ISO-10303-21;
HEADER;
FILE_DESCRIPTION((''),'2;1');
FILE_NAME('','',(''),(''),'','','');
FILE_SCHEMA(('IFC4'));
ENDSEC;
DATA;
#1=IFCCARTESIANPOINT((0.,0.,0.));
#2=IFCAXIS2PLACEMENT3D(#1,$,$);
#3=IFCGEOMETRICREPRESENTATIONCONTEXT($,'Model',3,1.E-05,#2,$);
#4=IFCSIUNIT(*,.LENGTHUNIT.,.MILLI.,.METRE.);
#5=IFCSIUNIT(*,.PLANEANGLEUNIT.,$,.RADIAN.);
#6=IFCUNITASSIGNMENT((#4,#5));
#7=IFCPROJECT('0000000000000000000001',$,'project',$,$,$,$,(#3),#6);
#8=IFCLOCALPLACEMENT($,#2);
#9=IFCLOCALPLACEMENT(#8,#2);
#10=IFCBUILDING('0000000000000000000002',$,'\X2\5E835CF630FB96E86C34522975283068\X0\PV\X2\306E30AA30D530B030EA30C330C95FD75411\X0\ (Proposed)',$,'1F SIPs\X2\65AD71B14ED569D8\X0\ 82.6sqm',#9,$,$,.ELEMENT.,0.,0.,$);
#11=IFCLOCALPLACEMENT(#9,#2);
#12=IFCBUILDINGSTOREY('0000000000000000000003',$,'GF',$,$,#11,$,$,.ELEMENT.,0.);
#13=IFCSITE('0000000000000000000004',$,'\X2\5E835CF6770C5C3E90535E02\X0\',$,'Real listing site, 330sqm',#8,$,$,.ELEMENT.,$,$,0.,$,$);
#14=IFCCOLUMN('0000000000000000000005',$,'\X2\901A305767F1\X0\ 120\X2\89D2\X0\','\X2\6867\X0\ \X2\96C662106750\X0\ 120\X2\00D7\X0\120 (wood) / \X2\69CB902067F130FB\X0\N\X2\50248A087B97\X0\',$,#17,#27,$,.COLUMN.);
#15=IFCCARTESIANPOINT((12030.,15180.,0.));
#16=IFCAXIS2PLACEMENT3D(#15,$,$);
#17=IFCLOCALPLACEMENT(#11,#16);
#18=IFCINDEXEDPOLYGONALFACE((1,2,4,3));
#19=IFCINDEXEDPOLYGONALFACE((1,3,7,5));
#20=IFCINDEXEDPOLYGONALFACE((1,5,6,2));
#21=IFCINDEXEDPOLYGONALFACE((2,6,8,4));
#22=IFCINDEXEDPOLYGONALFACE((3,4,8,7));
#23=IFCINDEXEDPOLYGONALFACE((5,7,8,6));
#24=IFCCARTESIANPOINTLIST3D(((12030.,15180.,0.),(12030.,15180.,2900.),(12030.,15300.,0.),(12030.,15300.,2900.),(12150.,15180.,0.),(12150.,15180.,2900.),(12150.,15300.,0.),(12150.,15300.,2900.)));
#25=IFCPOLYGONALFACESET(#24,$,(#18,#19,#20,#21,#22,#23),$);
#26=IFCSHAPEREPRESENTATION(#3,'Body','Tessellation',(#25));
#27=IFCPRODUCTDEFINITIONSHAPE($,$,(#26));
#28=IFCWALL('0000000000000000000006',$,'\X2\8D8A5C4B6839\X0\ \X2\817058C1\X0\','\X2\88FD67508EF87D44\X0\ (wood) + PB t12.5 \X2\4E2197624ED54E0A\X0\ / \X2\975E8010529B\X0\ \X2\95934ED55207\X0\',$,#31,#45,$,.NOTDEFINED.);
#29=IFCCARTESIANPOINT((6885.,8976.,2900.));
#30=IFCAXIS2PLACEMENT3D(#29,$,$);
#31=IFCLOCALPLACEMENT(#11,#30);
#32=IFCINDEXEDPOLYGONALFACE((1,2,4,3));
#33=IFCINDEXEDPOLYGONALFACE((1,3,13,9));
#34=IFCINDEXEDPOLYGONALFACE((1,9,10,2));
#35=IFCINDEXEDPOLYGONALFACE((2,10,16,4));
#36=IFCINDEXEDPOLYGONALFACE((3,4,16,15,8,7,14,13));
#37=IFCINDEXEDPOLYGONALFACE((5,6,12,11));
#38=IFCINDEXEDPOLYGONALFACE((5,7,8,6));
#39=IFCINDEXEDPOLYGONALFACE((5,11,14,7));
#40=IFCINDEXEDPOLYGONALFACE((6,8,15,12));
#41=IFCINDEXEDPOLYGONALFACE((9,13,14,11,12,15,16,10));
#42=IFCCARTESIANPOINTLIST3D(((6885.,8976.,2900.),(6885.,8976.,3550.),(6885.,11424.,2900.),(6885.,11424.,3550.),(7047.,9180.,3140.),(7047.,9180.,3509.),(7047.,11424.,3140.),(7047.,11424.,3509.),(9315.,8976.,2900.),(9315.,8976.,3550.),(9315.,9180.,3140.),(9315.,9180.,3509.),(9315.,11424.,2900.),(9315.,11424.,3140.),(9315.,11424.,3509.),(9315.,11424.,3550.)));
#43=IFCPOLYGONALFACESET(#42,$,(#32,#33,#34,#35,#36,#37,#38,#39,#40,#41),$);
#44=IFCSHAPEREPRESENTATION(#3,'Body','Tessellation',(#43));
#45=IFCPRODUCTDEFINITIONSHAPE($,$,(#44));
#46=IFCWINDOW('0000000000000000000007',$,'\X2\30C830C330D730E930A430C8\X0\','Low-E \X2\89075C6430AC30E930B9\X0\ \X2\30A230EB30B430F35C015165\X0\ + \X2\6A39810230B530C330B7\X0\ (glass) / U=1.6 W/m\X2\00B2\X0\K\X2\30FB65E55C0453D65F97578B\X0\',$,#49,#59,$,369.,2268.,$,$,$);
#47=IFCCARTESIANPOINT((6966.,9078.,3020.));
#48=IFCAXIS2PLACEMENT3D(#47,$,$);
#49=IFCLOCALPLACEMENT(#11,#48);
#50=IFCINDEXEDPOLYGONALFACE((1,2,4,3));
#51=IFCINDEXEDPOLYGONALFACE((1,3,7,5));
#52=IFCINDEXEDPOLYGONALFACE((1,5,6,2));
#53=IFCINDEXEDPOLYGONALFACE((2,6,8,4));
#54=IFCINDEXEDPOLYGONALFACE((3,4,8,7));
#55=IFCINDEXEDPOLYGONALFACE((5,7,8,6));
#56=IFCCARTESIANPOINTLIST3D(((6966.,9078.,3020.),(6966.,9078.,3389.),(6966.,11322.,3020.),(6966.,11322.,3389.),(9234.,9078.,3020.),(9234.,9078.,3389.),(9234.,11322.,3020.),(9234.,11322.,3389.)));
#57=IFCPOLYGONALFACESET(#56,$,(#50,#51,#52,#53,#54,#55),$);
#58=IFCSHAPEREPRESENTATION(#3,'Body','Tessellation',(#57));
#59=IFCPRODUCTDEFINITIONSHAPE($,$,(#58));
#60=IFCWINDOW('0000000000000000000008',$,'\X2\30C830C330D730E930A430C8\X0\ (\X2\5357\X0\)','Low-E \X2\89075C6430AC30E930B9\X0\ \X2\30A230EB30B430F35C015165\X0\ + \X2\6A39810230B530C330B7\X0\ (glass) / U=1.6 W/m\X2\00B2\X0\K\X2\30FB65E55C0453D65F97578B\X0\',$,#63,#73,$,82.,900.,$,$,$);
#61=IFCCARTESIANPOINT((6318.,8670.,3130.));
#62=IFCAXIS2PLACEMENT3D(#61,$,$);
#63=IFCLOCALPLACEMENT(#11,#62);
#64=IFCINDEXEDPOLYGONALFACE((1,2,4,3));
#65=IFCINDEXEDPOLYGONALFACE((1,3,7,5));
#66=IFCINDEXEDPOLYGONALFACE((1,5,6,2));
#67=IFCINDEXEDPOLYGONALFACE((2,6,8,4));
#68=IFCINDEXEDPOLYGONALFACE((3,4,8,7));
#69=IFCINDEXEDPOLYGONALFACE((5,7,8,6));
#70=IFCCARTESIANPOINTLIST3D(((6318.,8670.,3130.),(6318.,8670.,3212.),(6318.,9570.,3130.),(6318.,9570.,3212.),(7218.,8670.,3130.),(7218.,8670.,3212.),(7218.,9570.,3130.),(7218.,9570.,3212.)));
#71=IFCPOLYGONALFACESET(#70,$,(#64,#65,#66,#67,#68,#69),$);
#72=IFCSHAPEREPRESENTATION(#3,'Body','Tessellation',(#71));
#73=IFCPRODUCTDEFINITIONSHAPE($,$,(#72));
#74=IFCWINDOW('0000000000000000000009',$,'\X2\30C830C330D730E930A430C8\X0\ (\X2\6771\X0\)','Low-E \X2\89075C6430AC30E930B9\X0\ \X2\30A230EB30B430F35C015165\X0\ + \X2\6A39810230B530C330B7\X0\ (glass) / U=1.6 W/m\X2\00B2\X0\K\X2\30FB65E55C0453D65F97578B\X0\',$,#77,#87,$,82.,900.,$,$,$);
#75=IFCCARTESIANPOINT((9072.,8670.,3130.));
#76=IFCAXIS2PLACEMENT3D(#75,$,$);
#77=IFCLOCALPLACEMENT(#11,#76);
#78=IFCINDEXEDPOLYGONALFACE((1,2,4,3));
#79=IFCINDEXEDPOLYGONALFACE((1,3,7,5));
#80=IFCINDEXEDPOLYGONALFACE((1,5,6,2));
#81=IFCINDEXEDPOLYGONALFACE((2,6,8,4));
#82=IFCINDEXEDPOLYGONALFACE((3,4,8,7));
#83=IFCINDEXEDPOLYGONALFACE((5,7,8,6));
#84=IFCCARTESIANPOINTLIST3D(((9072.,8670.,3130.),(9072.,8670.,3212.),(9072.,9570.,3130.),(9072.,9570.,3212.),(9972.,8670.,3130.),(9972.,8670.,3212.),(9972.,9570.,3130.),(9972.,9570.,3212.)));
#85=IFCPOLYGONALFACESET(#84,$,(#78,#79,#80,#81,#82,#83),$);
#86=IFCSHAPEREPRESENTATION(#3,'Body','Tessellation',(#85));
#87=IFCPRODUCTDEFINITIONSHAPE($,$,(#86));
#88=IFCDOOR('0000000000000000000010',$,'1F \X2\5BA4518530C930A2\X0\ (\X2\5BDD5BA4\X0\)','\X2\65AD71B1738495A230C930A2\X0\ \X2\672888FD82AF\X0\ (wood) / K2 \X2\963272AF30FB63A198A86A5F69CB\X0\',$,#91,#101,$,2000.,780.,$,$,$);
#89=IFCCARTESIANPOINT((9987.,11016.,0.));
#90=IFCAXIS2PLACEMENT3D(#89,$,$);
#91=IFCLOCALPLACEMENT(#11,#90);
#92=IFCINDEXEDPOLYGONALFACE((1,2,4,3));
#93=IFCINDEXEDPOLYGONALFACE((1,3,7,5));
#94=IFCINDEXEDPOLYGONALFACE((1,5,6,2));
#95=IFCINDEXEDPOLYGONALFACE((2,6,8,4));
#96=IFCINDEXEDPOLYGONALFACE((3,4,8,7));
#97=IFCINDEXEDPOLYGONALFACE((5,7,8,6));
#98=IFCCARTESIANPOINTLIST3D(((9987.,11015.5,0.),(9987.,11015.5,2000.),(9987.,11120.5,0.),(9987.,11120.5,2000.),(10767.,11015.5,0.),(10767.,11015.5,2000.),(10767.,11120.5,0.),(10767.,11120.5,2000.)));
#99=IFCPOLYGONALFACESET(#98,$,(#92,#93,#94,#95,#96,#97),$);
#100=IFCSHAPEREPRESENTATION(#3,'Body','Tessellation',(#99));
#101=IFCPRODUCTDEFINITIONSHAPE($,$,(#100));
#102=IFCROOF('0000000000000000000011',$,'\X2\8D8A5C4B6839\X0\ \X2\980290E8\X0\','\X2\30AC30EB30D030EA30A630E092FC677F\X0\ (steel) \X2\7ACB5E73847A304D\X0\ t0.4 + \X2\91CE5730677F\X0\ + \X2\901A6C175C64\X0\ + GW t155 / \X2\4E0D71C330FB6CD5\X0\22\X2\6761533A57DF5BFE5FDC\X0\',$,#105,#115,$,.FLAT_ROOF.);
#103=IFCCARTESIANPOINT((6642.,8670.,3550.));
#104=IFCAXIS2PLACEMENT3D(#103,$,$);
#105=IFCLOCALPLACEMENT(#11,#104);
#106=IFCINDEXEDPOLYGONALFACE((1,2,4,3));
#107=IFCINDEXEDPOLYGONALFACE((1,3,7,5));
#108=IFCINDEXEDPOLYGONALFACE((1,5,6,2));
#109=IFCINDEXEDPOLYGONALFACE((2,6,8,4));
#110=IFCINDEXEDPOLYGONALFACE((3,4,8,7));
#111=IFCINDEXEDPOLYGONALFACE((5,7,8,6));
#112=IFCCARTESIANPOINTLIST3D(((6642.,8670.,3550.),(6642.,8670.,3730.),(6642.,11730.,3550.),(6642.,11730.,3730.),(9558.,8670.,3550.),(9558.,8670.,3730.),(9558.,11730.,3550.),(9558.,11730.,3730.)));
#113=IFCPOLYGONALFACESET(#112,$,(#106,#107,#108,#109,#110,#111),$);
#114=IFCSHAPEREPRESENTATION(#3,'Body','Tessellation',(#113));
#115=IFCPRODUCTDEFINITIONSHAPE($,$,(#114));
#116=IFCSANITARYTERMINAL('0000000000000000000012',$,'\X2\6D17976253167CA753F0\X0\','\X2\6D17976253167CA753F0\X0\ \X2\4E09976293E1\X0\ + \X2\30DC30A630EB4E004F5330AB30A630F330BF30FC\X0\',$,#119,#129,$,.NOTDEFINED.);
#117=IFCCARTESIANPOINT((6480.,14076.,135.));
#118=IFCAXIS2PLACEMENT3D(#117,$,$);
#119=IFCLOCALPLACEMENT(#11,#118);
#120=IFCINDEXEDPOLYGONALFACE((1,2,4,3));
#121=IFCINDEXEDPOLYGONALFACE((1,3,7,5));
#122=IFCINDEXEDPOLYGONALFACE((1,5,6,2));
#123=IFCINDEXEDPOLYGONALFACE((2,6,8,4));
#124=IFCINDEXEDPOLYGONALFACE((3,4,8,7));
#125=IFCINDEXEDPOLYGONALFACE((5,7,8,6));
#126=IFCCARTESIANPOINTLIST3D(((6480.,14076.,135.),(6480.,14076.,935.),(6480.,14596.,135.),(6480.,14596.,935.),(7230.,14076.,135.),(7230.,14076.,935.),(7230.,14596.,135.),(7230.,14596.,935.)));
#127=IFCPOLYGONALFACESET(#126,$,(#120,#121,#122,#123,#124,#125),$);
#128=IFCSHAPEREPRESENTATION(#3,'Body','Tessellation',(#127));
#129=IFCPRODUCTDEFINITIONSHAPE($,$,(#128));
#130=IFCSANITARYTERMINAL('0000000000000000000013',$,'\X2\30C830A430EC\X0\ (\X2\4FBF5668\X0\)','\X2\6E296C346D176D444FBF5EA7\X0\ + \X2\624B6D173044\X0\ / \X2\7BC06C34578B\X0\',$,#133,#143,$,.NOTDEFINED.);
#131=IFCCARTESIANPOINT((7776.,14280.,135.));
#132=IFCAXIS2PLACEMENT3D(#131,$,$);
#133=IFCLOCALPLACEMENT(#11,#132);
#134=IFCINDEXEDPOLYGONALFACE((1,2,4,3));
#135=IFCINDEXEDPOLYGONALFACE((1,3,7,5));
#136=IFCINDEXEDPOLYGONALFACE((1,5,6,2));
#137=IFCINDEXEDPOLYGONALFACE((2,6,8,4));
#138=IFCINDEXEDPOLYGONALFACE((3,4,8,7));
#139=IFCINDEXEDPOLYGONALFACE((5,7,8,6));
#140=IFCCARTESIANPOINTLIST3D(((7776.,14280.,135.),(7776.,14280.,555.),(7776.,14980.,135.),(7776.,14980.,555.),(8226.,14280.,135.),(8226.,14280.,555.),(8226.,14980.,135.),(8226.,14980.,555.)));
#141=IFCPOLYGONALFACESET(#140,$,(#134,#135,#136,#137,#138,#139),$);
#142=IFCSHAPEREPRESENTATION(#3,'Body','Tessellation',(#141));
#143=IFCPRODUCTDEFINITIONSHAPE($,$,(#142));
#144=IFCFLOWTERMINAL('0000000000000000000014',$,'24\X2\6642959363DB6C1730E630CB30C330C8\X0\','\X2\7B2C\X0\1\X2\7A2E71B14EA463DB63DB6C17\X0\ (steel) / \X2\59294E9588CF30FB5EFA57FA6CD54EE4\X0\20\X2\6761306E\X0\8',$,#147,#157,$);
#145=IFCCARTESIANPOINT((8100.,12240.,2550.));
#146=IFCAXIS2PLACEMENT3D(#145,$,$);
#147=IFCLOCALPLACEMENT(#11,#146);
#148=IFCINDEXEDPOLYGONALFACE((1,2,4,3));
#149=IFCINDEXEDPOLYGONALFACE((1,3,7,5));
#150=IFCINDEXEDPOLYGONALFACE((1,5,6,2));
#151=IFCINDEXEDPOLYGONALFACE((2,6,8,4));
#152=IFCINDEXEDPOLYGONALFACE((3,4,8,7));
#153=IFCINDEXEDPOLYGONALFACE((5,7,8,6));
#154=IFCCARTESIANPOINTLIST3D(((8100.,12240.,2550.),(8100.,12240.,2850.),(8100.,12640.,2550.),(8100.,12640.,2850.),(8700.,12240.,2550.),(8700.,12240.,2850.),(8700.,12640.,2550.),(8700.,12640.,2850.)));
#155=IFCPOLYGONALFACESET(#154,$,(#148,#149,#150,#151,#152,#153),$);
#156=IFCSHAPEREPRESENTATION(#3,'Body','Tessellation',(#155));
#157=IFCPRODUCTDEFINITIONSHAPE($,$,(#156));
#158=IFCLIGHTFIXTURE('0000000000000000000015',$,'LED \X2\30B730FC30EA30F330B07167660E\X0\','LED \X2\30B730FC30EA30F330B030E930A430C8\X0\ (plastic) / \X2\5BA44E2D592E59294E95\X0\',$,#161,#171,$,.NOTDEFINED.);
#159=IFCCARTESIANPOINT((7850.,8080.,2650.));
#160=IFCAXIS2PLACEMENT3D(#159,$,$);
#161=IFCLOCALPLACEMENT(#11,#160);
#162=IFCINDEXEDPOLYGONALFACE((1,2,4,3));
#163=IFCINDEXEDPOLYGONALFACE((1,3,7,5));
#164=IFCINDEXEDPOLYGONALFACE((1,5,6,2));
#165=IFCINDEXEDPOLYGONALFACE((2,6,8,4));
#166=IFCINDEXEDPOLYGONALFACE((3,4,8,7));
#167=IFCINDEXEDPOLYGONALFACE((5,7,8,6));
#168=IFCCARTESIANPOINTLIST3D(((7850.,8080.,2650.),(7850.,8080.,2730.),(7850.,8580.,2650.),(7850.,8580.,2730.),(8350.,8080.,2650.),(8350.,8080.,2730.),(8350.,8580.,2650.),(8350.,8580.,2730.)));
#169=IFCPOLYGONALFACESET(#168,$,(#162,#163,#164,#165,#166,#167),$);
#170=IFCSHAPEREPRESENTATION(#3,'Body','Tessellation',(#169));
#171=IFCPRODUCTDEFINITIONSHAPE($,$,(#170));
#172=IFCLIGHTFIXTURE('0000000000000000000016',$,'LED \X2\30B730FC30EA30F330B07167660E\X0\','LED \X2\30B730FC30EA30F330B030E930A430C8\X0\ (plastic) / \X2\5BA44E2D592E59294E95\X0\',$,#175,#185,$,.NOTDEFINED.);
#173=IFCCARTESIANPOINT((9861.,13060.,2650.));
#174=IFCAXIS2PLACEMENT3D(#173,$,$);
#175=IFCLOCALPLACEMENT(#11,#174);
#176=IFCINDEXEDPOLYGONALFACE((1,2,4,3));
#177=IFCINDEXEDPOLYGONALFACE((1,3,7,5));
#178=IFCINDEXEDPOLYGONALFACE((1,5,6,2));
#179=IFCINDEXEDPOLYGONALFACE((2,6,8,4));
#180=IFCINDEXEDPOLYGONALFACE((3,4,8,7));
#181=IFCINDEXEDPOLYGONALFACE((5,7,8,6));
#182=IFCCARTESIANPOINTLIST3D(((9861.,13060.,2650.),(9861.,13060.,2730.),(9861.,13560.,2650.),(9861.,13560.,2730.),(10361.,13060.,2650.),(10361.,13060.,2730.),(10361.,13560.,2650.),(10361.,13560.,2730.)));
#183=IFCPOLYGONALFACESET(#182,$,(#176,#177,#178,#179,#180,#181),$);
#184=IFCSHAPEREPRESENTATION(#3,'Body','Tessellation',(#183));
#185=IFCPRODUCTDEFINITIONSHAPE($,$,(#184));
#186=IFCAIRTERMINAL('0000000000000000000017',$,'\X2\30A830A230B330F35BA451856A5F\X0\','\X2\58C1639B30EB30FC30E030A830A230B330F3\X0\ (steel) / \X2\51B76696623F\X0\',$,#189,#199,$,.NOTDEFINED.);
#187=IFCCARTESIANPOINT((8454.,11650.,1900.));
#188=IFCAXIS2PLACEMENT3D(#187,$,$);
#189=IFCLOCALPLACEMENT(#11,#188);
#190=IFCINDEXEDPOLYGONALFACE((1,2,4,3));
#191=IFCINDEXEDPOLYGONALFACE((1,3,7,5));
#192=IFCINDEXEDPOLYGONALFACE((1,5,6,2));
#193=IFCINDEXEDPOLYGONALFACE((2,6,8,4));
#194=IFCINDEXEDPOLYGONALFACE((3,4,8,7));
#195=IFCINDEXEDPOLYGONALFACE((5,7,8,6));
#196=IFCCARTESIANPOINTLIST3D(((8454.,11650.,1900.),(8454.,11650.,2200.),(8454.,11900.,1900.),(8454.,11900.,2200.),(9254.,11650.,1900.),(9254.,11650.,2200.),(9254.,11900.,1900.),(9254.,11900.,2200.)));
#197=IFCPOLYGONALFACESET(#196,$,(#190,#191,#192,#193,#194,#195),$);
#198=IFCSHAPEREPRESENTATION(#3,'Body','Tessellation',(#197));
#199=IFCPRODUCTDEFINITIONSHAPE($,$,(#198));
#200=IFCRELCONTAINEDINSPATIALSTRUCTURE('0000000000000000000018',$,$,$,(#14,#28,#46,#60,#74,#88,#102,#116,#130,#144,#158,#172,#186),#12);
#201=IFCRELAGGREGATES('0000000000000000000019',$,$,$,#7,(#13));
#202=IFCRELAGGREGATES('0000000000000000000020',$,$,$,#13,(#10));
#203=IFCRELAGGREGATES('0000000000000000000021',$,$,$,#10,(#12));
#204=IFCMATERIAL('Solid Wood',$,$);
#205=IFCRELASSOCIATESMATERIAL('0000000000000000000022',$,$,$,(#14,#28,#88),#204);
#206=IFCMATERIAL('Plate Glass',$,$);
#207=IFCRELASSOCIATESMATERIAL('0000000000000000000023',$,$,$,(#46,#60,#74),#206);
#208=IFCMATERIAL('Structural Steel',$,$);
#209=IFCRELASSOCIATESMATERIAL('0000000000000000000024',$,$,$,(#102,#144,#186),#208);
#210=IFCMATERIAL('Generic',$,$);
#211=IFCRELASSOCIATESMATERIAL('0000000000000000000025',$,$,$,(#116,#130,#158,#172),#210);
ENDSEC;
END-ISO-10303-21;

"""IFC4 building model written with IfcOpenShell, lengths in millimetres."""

from ifc_helpers import new_model, si_unit, frame, frame_2d, origin, place, context, project, spatial, rectangle, extrude, material, element, fill, save


model = new_model("IFC4")

# Units and contexts
model_context = context("Model", 3, precision=1e-05, world=origin())
ifc_project = project(units=[si_unit("LENGTHUNIT", "METRE", prefix="MILLI"), si_unit("PLANEANGLEUNIT", "RADIAN")], contexts=[model_context])

# Site, building, storey
site_placement = place(None, origin())
site = spatial("IfcSite", under=ifc_project, at=site_placement, Name="広島県尾道市", ObjectType="Real listing site, 330sqm", CompositionType="ELEMENT", RefElevation=0.0)
building_placement = place(site_placement, origin())
building = spatial("IfcBuilding", under=site, at=building_placement, Name="広島・雨水利用とPVのオフグリッド志向 (Proposed)", ObjectType="1F SIPs断熱仕様 82.6sqm", CompositionType="ELEMENT", ElevationOfRefHeight=0.0, ElevationOfTerrain=0.0)
storey_placement = place(building_placement, origin())
storey = spatial("IfcBuildingStorey", under=building, at=storey_placement, Name="GF", CompositionType="ELEMENT", Elevation=0.0)

# Column
ifc_material_1 = material(Name="Solid Wood")
column_1_placement = place(storey_placement, frame((12030.0, 15180.0, 0.0)))
element("IfcColumn", 1, at=column_1_placement, inside=storey, material=ifc_material_1, Name="通し柱 120角", Description="桧 集成材 120×120 (wood) / 構造柱・N値計算", PredefinedType="COLUMN", context=model_context, shape_type="SweptSolid", body=[
    extrude(rectangle(XDim=120.0, YDim=120.0, at=frame_2d((60.0, 60.0))), frame((12030.0, 15180.0, 0.0)), (0.0, 0.0, 1.0), 2900.0),
])

# Wall, openings, windows
wall_1_placement = place(storey_placement, frame((6885.0, 8976.0, 2900.0)))
wall_1 = element("IfcWall", 2, at=wall_1_placement, inside=storey, material=ifc_material_1, Name="越屋根 腰壁", Description="製材軸組 (wood) + PB t12.5 両面仕上 / 非耐力 間仕切", PredefinedType="NOTDEFINED", context=model_context, shape_type="SweptSolid", body=[
    extrude(rectangle(XDim=2430.0, YDim=2448.0, at=frame_2d((1215.0, 1224.0))), frame((6885.0, 8976.0, 2900.0)), (0.0, 0.0, 1.0), 650.0),
])
opening_1_placement = place(storey_placement, frame((6966.0, 9078.0, 3020.0)))
opening_1 = element("IfcOpeningElement", 3, at=opening_1_placement, cuts=wall_1, PredefinedType="NOTDEFINED", context=model_context, shape_type="SweptSolid", body=[
    extrude(rectangle(XDim=2268.0, YDim=2244.0, at=frame_2d((1134.0, 1122.0))), frame((6966.0, 9078.0, 3020.0)), (0.0, 0.0, 1.0), 369.0),
])
opening_2_placement = place(storey_placement, frame((6318.0, 8670.0, 3130.0)))
opening_2 = element("IfcOpeningElement", 4, at=opening_2_placement, cuts=wall_1, PredefinedType="NOTDEFINED", context=model_context, shape_type="SweptSolid", body=[
    extrude(rectangle(XDim=900.0, YDim=900.0, at=frame_2d((450.0, 450.0))), frame((6318.0, 8670.0, 3130.0)), (0.0, 0.0, 1.0), 82.0),
])
opening_3_placement = place(storey_placement, frame((9072.0, 8670.0, 3130.0)))
opening_3 = element("IfcOpeningElement", 5, at=opening_3_placement, cuts=wall_1, PredefinedType="NOTDEFINED", context=model_context, shape_type="SweptSolid", body=[
    extrude(rectangle(XDim=900.0, YDim=900.0, at=frame_2d((450.0, 450.0))), frame((9072.0, 8670.0, 3130.0)), (0.0, 0.0, 1.0), 82.0),
])
ifc_material_2 = material(Name="Plate Glass")
window_1_placement = place(storey_placement, frame((6966.0, 9078.0, 3020.0)))
window_1 = element("IfcWindow", 6, at=window_1_placement, inside=storey, material=ifc_material_2, Name="トップライト", Description="Low-E 複層ガラス アルゴン封入 + 樹脂サッシ (glass) / U=1.6 W/m²K・日射取得型", OverallHeight=369.0, OverallWidth=2268.0, context=model_context, shape_type="SweptSolid", body=[
    extrude(rectangle(XDim=2268.0, YDim=2244.0, at=frame_2d((1134.0, 1122.0))), frame((6966.0, 9078.0, 3020.0)), (0.0, 0.0, 1.0), 369.0),
])
fill(opening_1, window_1)
window_2_placement = place(storey_placement, frame((6318.0, 8670.0, 3130.0)))
window_2 = element("IfcWindow", 7, at=window_2_placement, inside=storey, material=ifc_material_2, Name="トップライト (南)", Description="Low-E 複層ガラス アルゴン封入 + 樹脂サッシ (glass) / U=1.6 W/m²K・日射取得型", OverallHeight=82.0, OverallWidth=900.0, context=model_context, shape_type="SweptSolid", body=[
    extrude(rectangle(XDim=900.0, YDim=900.0, at=frame_2d((450.0, 450.0))), frame((6318.0, 8670.0, 3130.0)), (0.0, 0.0, 1.0), 82.0),
])
fill(opening_2, window_2)
window_3_placement = place(storey_placement, frame((9072.0, 8670.0, 3130.0)))
window_3 = element("IfcWindow", 8, at=window_3_placement, inside=storey, material=ifc_material_2, Name="トップライト (東)", Description="Low-E 複層ガラス アルゴン封入 + 樹脂サッシ (glass) / U=1.6 W/m²K・日射取得型", OverallHeight=82.0, OverallWidth=900.0, context=model_context, shape_type="SweptSolid", body=[
    extrude(rectangle(XDim=900.0, YDim=900.0, at=frame_2d((450.0, 450.0))), frame((9072.0, 8670.0, 3130.0)), (0.0, 0.0, 1.0), 82.0),
])
fill(opening_3, window_3)

# Door
door_placement = place(storey_placement, frame((9987.0, 11016.0, 0.0)))
element("IfcDoor", 9, at=door_placement, inside=storey, material=ifc_material_1, Name="1F 室内ドア (寝室)", Description="断熱玄関ドア 木製芯 (wood) / K2 防犯・採風機構", OverallHeight=2000.0, OverallWidth=780.0, context=model_context, shape_type="SweptSolid", body=[
    extrude(rectangle(XDim=780.0, YDim=105.0, at=frame_2d((390.0, 52.0))), frame((9987.0, 11016.0, 0.0)), (0.0, 0.0, 1.0), 2000.0),
])

# Roof
ifc_material_3 = material(Name="Structural Steel")
roof_placement = place(storey_placement, frame((6642.0, 8670.0, 3550.0)))
element("IfcRoof", 10, at=roof_placement, inside=storey, material=ifc_material_3, Name="越屋根 頂部", Description="ガルバリウム鋼板 (steel) 立平葺き t0.4 + 野地板 + 通気層 + GW t155 / 不燃・法22条区域対応", PredefinedType="FLAT_ROOF", context=model_context, shape_type="SweptSolid", body=[
    extrude(rectangle(XDim=2916.0, YDim=3060.0, at=frame_2d((1458.0, 1530.0))), frame((6642.0, 8670.0, 3550.0)), (0.0, 0.0, 1.0), 180.0),
])

# Sanitary terminals
ifc_material_4 = material(Name="Generic")
sanitary_terminal_1_placement = place(storey_placement, frame((6480.0, 14076.0, 135.0)))
element("IfcSanitaryTerminal", 11, at=sanitary_terminal_1_placement, inside=storey, material=ifc_material_4, Name="洗面化粧台", Description="洗面化粧台 三面鏡 + ボウル一体カウンター", PredefinedType="NOTDEFINED", context=model_context, shape_type="SweptSolid", body=[
    extrude(rectangle(XDim=750.0, YDim=520.0, at=frame_2d((375.0, 260.0))), frame((6480.0, 14076.0, 135.0)), (0.0, 0.0, 1.0), 800.0),
])
sanitary_terminal_2_placement = place(storey_placement, frame((7776.0, 14280.0, 135.0)))
element("IfcSanitaryTerminal", 12, at=sanitary_terminal_2_placement, inside=storey, material=ifc_material_4, Name="トイレ (便器)", Description="温水洗浄便座 + 手洗い / 節水型", PredefinedType="NOTDEFINED", context=model_context, shape_type="SweptSolid", body=[
    extrude(rectangle(XDim=450.0, YDim=700.0, at=frame_2d((225.0, 350.0))), frame((7776.0, 14280.0, 135.0)), (0.0, 0.0, 1.0), 420.0),
])

# Flow terminal
flow_terminal_placement = place(storey_placement, frame((8100.0, 12240.0, 2550.0)))
element("IfcFlowTerminal", 13, at=flow_terminal_placement, inside=storey, material=ifc_material_3, Name="24時間換気ユニット", Description="第1種熱交換換気 (steel) / 天井裏・建基法令20条の8", context=model_context, shape_type="SweptSolid", body=[
    extrude(rectangle(XDim=600.0, YDim=400.0, at=frame_2d((300.0, 200.0))), frame((8100.0, 12240.0, 2550.0)), (0.0, 0.0, 1.0), 300.0),
])

# Light fixtures
light_fixture_1_placement = place(storey_placement, frame((7850.0, 8080.0, 2650.0)))
element("IfcLightFixture", 14, at=light_fixture_1_placement, inside=storey, material=ifc_material_4, Name="LED シーリング照明", Description="LED シーリングライト (plastic) / 室中央天井", PredefinedType="NOTDEFINED", context=model_context, shape_type="SweptSolid", body=[
    extrude(rectangle(XDim=500.0, YDim=500.0, at=frame_2d((250.0, 250.0))), frame((7850.0, 8080.0, 2650.0)), (0.0, 0.0, 1.0), 80.0),
])
light_fixture_2_placement = place(storey_placement, frame((9861.0, 13060.0, 2650.0)))
element("IfcLightFixture", 15, at=light_fixture_2_placement, inside=storey, material=ifc_material_4, Name="LED シーリング照明", Description="LED シーリングライト (plastic) / 室中央天井", PredefinedType="NOTDEFINED", context=model_context, shape_type="SweptSolid", body=[
    extrude(rectangle(XDim=500.0, YDim=500.0, at=frame_2d((250.0, 250.0))), frame((9861.0, 13060.0, 2650.0)), (0.0, 0.0, 1.0), 80.0),
])

# Air terminal
air_terminal_placement = place(storey_placement, frame((8454.0, 11650.0, 1900.0)))
element("IfcAirTerminal", 16, at=air_terminal_placement, inside=storey, material=ifc_material_3, Name="エアコン室内機", Description="壁掛ルームエアコン (steel) / 冷暖房", PredefinedType="NOTDEFINED", context=model_context, shape_type="SweptSolid", body=[
    extrude(rectangle(XDim=800.0, YDim=250.0, at=frame_2d((400.0, 125.0))), frame((8454.0, 11650.0, 1900.0)), (0.0, 0.0, 1.0), 300.0),
])

save(model, "model.ifc")
